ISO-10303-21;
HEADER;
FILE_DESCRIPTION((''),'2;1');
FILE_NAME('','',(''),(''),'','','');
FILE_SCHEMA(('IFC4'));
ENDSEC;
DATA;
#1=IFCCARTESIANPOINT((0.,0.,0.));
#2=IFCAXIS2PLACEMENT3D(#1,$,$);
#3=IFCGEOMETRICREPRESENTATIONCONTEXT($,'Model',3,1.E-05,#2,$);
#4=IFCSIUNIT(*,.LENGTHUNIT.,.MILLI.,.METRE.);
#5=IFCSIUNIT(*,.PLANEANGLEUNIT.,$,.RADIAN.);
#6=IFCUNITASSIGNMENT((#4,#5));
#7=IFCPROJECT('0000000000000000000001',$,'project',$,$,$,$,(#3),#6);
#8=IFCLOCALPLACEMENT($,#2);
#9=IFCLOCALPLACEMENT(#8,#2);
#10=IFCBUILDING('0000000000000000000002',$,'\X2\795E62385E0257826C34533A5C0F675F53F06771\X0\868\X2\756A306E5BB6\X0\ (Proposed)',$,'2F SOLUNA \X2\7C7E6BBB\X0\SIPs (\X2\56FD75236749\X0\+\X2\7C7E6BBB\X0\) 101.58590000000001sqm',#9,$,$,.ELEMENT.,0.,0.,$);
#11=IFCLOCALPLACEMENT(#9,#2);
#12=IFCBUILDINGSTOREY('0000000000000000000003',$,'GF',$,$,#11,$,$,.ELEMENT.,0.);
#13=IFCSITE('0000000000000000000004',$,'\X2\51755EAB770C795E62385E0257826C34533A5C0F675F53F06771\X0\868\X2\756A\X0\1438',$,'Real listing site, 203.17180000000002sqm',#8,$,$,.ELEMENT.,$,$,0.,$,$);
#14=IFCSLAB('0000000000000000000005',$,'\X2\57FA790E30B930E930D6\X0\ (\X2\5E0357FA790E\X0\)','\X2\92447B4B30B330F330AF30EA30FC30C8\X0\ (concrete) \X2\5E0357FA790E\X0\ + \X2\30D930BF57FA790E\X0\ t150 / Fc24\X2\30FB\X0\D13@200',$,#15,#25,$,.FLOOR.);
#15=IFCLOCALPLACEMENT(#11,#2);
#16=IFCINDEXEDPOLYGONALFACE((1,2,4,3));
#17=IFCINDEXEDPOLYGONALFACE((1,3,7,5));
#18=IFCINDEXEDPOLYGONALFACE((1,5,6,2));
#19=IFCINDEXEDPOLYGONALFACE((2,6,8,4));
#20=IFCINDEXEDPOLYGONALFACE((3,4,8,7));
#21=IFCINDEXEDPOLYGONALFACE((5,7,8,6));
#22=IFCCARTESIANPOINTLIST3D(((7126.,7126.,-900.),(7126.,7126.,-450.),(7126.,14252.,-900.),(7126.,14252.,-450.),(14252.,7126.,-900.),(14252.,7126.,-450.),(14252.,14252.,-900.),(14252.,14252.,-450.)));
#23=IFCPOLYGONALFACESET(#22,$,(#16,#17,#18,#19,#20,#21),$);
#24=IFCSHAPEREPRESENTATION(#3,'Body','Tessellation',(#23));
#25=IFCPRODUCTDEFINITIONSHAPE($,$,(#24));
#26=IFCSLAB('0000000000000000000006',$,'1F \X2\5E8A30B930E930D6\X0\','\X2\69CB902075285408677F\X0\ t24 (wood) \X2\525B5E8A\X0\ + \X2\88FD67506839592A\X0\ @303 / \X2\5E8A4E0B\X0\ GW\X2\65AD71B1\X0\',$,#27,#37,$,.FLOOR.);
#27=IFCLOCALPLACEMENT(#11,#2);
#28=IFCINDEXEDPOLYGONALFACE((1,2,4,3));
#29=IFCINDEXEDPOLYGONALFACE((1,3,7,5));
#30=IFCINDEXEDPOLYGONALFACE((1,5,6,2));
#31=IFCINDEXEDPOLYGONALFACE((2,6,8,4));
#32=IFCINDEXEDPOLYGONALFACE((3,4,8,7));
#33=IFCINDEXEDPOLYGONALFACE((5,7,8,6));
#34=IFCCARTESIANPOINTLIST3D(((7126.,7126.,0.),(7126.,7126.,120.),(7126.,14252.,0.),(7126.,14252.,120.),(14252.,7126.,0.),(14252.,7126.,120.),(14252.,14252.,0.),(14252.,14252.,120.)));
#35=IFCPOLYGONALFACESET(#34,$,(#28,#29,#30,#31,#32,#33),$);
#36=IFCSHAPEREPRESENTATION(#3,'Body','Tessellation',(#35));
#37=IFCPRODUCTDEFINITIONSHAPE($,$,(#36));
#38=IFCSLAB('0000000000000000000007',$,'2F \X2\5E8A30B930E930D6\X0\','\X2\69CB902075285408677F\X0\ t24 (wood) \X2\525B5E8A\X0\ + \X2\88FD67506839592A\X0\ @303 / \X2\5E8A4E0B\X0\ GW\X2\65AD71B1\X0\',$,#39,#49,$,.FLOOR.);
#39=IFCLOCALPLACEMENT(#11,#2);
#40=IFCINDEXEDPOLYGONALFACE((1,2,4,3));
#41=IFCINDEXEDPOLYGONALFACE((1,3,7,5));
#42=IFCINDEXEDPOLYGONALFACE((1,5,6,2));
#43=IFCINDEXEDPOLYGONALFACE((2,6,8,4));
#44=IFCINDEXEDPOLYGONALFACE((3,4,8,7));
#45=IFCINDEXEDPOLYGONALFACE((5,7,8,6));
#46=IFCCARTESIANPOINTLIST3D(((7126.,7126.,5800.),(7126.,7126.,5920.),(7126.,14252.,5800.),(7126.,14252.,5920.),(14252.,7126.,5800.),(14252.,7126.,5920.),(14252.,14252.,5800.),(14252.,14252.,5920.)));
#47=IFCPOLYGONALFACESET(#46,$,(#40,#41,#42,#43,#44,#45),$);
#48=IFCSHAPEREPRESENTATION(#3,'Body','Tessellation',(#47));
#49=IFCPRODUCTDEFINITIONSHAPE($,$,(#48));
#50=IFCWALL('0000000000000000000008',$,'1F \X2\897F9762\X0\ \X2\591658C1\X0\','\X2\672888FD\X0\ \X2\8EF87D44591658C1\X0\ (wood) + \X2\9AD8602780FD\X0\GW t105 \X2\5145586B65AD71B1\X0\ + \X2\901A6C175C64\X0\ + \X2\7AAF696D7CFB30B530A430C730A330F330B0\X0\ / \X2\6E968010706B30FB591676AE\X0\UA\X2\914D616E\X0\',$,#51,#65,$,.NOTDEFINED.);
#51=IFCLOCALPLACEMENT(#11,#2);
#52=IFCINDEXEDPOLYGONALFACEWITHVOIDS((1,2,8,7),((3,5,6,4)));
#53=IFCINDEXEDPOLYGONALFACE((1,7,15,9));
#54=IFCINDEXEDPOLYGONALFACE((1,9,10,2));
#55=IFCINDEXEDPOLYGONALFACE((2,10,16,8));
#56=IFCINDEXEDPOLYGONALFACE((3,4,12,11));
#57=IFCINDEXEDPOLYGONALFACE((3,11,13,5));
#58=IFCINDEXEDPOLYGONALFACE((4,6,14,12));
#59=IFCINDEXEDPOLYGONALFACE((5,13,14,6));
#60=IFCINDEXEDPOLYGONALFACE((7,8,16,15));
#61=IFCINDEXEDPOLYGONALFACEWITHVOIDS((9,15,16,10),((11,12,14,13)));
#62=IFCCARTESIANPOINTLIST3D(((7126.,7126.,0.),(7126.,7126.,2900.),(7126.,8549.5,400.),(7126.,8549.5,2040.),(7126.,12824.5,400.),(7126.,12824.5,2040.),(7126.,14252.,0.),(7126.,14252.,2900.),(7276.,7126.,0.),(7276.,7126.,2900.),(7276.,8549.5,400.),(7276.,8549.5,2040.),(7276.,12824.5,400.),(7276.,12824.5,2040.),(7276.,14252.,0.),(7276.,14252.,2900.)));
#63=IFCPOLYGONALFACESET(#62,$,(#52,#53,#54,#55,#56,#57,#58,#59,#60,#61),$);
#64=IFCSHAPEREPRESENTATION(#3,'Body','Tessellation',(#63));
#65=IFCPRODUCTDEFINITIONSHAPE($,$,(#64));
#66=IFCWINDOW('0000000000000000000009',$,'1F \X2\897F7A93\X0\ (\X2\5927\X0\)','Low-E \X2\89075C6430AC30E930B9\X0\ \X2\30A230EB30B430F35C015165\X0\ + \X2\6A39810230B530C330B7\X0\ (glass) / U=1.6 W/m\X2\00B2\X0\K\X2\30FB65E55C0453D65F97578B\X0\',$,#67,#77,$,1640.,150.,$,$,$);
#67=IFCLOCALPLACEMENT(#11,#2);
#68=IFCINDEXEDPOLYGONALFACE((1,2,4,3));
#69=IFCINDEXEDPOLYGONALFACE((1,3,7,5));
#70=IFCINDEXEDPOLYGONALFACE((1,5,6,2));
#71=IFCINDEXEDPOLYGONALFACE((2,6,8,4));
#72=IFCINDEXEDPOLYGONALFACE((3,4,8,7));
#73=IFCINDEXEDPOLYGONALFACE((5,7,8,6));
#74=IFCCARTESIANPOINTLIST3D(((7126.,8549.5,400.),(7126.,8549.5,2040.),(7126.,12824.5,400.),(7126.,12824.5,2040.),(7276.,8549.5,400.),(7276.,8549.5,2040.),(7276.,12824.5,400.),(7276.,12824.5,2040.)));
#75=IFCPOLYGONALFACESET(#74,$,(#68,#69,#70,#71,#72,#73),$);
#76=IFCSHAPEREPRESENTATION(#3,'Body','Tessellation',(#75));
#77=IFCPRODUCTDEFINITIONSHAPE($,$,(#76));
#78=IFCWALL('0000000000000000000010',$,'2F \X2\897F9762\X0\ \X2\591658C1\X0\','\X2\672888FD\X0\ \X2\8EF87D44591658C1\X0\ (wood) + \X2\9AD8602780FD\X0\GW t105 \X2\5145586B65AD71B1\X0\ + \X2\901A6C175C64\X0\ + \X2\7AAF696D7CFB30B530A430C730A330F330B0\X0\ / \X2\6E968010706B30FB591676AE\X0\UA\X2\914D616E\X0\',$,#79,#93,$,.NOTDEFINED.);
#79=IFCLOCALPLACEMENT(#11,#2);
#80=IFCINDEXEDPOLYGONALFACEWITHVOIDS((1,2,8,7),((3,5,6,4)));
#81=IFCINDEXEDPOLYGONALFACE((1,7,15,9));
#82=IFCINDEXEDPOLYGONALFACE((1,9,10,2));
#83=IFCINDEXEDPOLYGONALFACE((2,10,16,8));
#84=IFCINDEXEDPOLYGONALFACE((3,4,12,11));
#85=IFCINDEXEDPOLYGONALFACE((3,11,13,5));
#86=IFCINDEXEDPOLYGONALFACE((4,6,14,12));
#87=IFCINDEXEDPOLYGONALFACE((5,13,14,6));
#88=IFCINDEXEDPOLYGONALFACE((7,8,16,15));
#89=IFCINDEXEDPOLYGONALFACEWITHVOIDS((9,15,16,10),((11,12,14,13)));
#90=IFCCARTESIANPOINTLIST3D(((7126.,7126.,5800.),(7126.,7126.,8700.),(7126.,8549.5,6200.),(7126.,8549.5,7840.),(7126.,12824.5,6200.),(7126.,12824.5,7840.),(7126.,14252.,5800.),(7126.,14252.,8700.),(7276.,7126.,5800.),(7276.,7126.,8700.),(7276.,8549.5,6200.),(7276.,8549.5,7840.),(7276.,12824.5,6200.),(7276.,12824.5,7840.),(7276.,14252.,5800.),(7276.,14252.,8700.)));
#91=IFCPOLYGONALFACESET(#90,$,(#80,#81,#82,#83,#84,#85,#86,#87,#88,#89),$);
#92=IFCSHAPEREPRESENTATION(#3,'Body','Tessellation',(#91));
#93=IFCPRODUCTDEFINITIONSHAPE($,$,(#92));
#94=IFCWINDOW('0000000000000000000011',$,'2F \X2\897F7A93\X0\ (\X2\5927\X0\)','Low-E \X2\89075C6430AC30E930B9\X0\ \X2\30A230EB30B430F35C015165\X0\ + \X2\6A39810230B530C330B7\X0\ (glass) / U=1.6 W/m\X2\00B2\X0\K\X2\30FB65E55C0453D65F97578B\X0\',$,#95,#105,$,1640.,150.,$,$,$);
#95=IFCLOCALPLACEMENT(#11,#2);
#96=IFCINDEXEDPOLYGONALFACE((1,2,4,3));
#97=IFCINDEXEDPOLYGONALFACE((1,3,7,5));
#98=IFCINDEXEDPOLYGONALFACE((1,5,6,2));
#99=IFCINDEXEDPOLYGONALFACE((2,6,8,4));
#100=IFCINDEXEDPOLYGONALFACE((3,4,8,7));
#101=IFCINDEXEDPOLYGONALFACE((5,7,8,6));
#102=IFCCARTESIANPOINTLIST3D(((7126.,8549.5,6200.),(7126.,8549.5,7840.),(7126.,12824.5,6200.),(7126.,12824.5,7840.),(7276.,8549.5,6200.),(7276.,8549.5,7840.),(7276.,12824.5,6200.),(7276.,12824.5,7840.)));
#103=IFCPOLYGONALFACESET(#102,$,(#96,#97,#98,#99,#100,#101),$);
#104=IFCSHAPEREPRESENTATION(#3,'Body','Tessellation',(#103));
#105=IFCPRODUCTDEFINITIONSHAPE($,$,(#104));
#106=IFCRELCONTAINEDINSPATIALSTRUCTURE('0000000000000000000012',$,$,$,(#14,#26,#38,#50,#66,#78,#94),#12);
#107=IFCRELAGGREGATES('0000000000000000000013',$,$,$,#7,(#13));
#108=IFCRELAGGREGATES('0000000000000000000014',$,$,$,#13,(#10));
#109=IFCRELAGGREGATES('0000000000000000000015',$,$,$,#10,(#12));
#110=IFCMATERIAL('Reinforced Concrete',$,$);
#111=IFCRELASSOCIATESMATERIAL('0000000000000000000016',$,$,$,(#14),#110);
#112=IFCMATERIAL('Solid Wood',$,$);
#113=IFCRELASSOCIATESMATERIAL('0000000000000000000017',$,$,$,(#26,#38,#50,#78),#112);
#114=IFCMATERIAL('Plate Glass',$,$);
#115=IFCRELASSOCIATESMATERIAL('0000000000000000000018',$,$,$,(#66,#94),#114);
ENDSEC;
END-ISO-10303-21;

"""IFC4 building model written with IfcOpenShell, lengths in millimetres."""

from ifc_helpers import new_model, si_unit, frame, frame_2d, origin, place, context, project, spatial, rectangle, extrude, material, element, fill, save


model = new_model("IFC4")

# Units and contexts
model_context = context("Model", 3, precision=1e-05, world=origin())
ifc_project = project(units=[si_unit("LENGTHUNIT", "METRE", prefix="MILLI"), si_unit("PLANEANGLEUNIT", "RADIAN")], contexts=[model_context])

# Site, building, storey
site_placement = place(None, origin())
site = spatial("IfcSite", under=ifc_project, at=site_placement, Name="兵庫県神戸市垂水区小束台東868番1438", ObjectType="Real listing site, 203.17180000000002sqm", CompositionType="ELEMENT", RefElevation=0.0)
building_placement = place(site_placement, origin())
building = spatial("IfcBuilding", under=site, at=building_placement, Name="神戸市垂水区小束台東868番の家 (Proposed)", ObjectType="2F SOLUNA 籾殻SIPs (国産杉+籾殻) 101.58590000000001sqm", CompositionType="ELEMENT", ElevationOfRefHeight=0.0, ElevationOfTerrain=0.0)
storey_placement = place(building_placement, origin())
storey = spatial("IfcBuildingStorey", under=building, at=storey_placement, Name="GF", CompositionType="ELEMENT", Elevation=0.0)

# Slabs
ifc_material_1 = material(Name="Reinforced Concrete")
slab_1_placement = place(storey_placement, frame((3563.0, 3563.0, -450.0)))
element("IfcSlab", 1, at=slab_1_placement, inside=storey, material=ifc_material_1, Name="基礎スラブ (布基礎)", Description="鉄筋コンクリート (concrete) 布基礎 + ベタ基礎 t150 / Fc24・D13@200", PredefinedType="FLOOR", context=model_context, shape_type="SweptSolid", body=[
    extrude(rectangle(XDim=7126.0, YDim=7126.0, at=frame_2d((3563.0, 3563.0))), frame((3563.0, 3563.0, -450.0)), (0.0, 0.0, 1.0), 450.0),
])
ifc_material_2 = material(Name="Solid Wood")
slab_2_placement = place(storey_placement, frame((3563.0, 3563.0, 0.0)))
element("IfcSlab", 2, at=slab_2_placement, inside=storey, material=ifc_material_2, Name="1F 床スラブ", Description="構造用合板 t24 (wood) 剛床 + 製材根太 @303 / 床下 GW断熱", PredefinedType="FLOOR", context=model_context, shape_type="SweptSolid", body=[
    extrude(rectangle(XDim=7126.0, YDim=7126.0, at=frame_2d((3563.0, 3563.0))), frame((3563.0, 3563.0, 0.0)), (0.0, 0.0, 1.0), 120.0),
])
slab_3_placement = place(storey_placement, frame((3563.0, 3563.0, 2900.0)))
element("IfcSlab", 3, at=slab_3_placement, inside=storey, material=ifc_material_2, Name="2F 床スラブ", Description="構造用合板 t24 (wood) 剛床 + 製材根太 @303 / 床下 GW断熱", PredefinedType="FLOOR", context=model_context, shape_type="SweptSolid", body=[
    extrude(rectangle(XDim=7126.0, YDim=7126.0, at=frame_2d((3563.0, 3563.0))), frame((3563.0, 3563.0, 2900.0)), (0.0, 0.0, 1.0), 120.0),
])

# Shared definitions
ifc_material_3 = material(Name="Plate Glass")

# Wall, opening, window
wall_1_placement = place(storey_placement, frame((3563.0, 3563.0, 0.0)))
wall_1 = element("IfcWall", 4, at=wall_1_placement, inside=storey, material=ifc_material_2, Name="1F 西面 外壁", Description="木製 軸組外壁 (wood) + 高性能GW t105 充填断熱 + 通気層 + 窯業系サイディング / 準耐火・外皮UA配慮", PredefinedType="NOTDEFINED", context=model_context, shape_type="SweptSolid", body=[
    extrude(rectangle(XDim=150.0, YDim=7126.0, at=frame_2d((75.0, 3563.0))), frame((3563.0, 3563.0, 0.0)), (0.0, 0.0, 1.0), 2900.0),
])
opening_1_placement = place(storey_placement, frame((3563.0, 4275.0, 200.0)))
opening_1 = element("IfcOpeningElement", 5, at=opening_1_placement, cuts=wall_1, PredefinedType="NOTDEFINED", context=model_context, shape_type="SweptSolid", body=[
    extrude(rectangle(XDim=150.0, YDim=4275.0, at=frame_2d((75.0, 2137.0))), frame((3563.0, 4275.0, 200.0)), (0.0, 0.0, 1.0), 1640.0),
])
window_1_placement = place(storey_placement, frame((3563.0, 4275.0, 200.0)))
window_1 = element("IfcWindow", 6, at=window_1_placement, inside=storey, material=ifc_material_3, Name="1F 西窓 (大)", Description="Low-E 複層ガラス アルゴン封入 + 樹脂サッシ (glass) / U=1.6 W/m²K・日射取得型", OverallHeight=1640.0, OverallWidth=150.0, context=model_context, shape_type="SweptSolid", body=[
    extrude(rectangle(XDim=150.0, YDim=4275.0, at=frame_2d((75.0, 2137.0))), frame((3563.0, 4275.0, 200.0)), (0.0, 0.0, 1.0), 1640.0),
])
fill(opening_1, window_1)

# Wall, opening, window
wall_2_placement = place(storey_placement, frame((3563.0, 3563.0, 2900.0)))
wall_2 = element("IfcWall", 7, at=wall_2_placement, inside=storey, material=ifc_material_2, Name="2F 西面 外壁", Description="木製 軸組外壁 (wood) + 高性能GW t105 充填断熱 + 通気層 + 窯業系サイディング / 準耐火・外皮UA配慮", PredefinedType="NOTDEFINED", context=model_context, shape_type="SweptSolid", body=[
    extrude(rectangle(XDim=150.0, YDim=7126.0, at=frame_2d((75.0, 3563.0))), frame((3563.0, 3563.0, 2900.0)), (0.0, 0.0, 1.0), 2900.0),
])
opening_2_placement = place(storey_placement, frame((3563.0, 4275.0, 3100.0)))
opening_2 = element("IfcOpeningElement", 8, at=opening_2_placement, cuts=wall_2, PredefinedType="NOTDEFINED", context=model_context, shape_type="SweptSolid", body=[
    extrude(rectangle(XDim=150.0, YDim=4275.0, at=frame_2d((75.0, 2137.0))), frame((3563.0, 4275.0, 3100.0)), (0.0, 0.0, 1.0), 1640.0),
])
window_2_placement = place(storey_placement, frame((3563.0, 4275.0, 3100.0)))
window_2 = element("IfcWindow", 9, at=window_2_placement, inside=storey, material=ifc_material_3, Name="2F 西窓 (大)", Description="Low-E 複層ガラス アルゴン封入 + 樹脂サッシ (glass) / U=1.6 W/m²K・日射取得型", OverallHeight=1640.0, OverallWidth=150.0, context=model_context, shape_type="SweptSolid", body=[
    extrude(rectangle(XDim=150.0, YDim=4275.0, at=frame_2d((75.0, 2137.0))), frame((3563.0, 4275.0, 3100.0)), (0.0, 0.0, 1.0), 1640.0),
])
fill(opening_2, window_2)

save(model, "model.ifc")
